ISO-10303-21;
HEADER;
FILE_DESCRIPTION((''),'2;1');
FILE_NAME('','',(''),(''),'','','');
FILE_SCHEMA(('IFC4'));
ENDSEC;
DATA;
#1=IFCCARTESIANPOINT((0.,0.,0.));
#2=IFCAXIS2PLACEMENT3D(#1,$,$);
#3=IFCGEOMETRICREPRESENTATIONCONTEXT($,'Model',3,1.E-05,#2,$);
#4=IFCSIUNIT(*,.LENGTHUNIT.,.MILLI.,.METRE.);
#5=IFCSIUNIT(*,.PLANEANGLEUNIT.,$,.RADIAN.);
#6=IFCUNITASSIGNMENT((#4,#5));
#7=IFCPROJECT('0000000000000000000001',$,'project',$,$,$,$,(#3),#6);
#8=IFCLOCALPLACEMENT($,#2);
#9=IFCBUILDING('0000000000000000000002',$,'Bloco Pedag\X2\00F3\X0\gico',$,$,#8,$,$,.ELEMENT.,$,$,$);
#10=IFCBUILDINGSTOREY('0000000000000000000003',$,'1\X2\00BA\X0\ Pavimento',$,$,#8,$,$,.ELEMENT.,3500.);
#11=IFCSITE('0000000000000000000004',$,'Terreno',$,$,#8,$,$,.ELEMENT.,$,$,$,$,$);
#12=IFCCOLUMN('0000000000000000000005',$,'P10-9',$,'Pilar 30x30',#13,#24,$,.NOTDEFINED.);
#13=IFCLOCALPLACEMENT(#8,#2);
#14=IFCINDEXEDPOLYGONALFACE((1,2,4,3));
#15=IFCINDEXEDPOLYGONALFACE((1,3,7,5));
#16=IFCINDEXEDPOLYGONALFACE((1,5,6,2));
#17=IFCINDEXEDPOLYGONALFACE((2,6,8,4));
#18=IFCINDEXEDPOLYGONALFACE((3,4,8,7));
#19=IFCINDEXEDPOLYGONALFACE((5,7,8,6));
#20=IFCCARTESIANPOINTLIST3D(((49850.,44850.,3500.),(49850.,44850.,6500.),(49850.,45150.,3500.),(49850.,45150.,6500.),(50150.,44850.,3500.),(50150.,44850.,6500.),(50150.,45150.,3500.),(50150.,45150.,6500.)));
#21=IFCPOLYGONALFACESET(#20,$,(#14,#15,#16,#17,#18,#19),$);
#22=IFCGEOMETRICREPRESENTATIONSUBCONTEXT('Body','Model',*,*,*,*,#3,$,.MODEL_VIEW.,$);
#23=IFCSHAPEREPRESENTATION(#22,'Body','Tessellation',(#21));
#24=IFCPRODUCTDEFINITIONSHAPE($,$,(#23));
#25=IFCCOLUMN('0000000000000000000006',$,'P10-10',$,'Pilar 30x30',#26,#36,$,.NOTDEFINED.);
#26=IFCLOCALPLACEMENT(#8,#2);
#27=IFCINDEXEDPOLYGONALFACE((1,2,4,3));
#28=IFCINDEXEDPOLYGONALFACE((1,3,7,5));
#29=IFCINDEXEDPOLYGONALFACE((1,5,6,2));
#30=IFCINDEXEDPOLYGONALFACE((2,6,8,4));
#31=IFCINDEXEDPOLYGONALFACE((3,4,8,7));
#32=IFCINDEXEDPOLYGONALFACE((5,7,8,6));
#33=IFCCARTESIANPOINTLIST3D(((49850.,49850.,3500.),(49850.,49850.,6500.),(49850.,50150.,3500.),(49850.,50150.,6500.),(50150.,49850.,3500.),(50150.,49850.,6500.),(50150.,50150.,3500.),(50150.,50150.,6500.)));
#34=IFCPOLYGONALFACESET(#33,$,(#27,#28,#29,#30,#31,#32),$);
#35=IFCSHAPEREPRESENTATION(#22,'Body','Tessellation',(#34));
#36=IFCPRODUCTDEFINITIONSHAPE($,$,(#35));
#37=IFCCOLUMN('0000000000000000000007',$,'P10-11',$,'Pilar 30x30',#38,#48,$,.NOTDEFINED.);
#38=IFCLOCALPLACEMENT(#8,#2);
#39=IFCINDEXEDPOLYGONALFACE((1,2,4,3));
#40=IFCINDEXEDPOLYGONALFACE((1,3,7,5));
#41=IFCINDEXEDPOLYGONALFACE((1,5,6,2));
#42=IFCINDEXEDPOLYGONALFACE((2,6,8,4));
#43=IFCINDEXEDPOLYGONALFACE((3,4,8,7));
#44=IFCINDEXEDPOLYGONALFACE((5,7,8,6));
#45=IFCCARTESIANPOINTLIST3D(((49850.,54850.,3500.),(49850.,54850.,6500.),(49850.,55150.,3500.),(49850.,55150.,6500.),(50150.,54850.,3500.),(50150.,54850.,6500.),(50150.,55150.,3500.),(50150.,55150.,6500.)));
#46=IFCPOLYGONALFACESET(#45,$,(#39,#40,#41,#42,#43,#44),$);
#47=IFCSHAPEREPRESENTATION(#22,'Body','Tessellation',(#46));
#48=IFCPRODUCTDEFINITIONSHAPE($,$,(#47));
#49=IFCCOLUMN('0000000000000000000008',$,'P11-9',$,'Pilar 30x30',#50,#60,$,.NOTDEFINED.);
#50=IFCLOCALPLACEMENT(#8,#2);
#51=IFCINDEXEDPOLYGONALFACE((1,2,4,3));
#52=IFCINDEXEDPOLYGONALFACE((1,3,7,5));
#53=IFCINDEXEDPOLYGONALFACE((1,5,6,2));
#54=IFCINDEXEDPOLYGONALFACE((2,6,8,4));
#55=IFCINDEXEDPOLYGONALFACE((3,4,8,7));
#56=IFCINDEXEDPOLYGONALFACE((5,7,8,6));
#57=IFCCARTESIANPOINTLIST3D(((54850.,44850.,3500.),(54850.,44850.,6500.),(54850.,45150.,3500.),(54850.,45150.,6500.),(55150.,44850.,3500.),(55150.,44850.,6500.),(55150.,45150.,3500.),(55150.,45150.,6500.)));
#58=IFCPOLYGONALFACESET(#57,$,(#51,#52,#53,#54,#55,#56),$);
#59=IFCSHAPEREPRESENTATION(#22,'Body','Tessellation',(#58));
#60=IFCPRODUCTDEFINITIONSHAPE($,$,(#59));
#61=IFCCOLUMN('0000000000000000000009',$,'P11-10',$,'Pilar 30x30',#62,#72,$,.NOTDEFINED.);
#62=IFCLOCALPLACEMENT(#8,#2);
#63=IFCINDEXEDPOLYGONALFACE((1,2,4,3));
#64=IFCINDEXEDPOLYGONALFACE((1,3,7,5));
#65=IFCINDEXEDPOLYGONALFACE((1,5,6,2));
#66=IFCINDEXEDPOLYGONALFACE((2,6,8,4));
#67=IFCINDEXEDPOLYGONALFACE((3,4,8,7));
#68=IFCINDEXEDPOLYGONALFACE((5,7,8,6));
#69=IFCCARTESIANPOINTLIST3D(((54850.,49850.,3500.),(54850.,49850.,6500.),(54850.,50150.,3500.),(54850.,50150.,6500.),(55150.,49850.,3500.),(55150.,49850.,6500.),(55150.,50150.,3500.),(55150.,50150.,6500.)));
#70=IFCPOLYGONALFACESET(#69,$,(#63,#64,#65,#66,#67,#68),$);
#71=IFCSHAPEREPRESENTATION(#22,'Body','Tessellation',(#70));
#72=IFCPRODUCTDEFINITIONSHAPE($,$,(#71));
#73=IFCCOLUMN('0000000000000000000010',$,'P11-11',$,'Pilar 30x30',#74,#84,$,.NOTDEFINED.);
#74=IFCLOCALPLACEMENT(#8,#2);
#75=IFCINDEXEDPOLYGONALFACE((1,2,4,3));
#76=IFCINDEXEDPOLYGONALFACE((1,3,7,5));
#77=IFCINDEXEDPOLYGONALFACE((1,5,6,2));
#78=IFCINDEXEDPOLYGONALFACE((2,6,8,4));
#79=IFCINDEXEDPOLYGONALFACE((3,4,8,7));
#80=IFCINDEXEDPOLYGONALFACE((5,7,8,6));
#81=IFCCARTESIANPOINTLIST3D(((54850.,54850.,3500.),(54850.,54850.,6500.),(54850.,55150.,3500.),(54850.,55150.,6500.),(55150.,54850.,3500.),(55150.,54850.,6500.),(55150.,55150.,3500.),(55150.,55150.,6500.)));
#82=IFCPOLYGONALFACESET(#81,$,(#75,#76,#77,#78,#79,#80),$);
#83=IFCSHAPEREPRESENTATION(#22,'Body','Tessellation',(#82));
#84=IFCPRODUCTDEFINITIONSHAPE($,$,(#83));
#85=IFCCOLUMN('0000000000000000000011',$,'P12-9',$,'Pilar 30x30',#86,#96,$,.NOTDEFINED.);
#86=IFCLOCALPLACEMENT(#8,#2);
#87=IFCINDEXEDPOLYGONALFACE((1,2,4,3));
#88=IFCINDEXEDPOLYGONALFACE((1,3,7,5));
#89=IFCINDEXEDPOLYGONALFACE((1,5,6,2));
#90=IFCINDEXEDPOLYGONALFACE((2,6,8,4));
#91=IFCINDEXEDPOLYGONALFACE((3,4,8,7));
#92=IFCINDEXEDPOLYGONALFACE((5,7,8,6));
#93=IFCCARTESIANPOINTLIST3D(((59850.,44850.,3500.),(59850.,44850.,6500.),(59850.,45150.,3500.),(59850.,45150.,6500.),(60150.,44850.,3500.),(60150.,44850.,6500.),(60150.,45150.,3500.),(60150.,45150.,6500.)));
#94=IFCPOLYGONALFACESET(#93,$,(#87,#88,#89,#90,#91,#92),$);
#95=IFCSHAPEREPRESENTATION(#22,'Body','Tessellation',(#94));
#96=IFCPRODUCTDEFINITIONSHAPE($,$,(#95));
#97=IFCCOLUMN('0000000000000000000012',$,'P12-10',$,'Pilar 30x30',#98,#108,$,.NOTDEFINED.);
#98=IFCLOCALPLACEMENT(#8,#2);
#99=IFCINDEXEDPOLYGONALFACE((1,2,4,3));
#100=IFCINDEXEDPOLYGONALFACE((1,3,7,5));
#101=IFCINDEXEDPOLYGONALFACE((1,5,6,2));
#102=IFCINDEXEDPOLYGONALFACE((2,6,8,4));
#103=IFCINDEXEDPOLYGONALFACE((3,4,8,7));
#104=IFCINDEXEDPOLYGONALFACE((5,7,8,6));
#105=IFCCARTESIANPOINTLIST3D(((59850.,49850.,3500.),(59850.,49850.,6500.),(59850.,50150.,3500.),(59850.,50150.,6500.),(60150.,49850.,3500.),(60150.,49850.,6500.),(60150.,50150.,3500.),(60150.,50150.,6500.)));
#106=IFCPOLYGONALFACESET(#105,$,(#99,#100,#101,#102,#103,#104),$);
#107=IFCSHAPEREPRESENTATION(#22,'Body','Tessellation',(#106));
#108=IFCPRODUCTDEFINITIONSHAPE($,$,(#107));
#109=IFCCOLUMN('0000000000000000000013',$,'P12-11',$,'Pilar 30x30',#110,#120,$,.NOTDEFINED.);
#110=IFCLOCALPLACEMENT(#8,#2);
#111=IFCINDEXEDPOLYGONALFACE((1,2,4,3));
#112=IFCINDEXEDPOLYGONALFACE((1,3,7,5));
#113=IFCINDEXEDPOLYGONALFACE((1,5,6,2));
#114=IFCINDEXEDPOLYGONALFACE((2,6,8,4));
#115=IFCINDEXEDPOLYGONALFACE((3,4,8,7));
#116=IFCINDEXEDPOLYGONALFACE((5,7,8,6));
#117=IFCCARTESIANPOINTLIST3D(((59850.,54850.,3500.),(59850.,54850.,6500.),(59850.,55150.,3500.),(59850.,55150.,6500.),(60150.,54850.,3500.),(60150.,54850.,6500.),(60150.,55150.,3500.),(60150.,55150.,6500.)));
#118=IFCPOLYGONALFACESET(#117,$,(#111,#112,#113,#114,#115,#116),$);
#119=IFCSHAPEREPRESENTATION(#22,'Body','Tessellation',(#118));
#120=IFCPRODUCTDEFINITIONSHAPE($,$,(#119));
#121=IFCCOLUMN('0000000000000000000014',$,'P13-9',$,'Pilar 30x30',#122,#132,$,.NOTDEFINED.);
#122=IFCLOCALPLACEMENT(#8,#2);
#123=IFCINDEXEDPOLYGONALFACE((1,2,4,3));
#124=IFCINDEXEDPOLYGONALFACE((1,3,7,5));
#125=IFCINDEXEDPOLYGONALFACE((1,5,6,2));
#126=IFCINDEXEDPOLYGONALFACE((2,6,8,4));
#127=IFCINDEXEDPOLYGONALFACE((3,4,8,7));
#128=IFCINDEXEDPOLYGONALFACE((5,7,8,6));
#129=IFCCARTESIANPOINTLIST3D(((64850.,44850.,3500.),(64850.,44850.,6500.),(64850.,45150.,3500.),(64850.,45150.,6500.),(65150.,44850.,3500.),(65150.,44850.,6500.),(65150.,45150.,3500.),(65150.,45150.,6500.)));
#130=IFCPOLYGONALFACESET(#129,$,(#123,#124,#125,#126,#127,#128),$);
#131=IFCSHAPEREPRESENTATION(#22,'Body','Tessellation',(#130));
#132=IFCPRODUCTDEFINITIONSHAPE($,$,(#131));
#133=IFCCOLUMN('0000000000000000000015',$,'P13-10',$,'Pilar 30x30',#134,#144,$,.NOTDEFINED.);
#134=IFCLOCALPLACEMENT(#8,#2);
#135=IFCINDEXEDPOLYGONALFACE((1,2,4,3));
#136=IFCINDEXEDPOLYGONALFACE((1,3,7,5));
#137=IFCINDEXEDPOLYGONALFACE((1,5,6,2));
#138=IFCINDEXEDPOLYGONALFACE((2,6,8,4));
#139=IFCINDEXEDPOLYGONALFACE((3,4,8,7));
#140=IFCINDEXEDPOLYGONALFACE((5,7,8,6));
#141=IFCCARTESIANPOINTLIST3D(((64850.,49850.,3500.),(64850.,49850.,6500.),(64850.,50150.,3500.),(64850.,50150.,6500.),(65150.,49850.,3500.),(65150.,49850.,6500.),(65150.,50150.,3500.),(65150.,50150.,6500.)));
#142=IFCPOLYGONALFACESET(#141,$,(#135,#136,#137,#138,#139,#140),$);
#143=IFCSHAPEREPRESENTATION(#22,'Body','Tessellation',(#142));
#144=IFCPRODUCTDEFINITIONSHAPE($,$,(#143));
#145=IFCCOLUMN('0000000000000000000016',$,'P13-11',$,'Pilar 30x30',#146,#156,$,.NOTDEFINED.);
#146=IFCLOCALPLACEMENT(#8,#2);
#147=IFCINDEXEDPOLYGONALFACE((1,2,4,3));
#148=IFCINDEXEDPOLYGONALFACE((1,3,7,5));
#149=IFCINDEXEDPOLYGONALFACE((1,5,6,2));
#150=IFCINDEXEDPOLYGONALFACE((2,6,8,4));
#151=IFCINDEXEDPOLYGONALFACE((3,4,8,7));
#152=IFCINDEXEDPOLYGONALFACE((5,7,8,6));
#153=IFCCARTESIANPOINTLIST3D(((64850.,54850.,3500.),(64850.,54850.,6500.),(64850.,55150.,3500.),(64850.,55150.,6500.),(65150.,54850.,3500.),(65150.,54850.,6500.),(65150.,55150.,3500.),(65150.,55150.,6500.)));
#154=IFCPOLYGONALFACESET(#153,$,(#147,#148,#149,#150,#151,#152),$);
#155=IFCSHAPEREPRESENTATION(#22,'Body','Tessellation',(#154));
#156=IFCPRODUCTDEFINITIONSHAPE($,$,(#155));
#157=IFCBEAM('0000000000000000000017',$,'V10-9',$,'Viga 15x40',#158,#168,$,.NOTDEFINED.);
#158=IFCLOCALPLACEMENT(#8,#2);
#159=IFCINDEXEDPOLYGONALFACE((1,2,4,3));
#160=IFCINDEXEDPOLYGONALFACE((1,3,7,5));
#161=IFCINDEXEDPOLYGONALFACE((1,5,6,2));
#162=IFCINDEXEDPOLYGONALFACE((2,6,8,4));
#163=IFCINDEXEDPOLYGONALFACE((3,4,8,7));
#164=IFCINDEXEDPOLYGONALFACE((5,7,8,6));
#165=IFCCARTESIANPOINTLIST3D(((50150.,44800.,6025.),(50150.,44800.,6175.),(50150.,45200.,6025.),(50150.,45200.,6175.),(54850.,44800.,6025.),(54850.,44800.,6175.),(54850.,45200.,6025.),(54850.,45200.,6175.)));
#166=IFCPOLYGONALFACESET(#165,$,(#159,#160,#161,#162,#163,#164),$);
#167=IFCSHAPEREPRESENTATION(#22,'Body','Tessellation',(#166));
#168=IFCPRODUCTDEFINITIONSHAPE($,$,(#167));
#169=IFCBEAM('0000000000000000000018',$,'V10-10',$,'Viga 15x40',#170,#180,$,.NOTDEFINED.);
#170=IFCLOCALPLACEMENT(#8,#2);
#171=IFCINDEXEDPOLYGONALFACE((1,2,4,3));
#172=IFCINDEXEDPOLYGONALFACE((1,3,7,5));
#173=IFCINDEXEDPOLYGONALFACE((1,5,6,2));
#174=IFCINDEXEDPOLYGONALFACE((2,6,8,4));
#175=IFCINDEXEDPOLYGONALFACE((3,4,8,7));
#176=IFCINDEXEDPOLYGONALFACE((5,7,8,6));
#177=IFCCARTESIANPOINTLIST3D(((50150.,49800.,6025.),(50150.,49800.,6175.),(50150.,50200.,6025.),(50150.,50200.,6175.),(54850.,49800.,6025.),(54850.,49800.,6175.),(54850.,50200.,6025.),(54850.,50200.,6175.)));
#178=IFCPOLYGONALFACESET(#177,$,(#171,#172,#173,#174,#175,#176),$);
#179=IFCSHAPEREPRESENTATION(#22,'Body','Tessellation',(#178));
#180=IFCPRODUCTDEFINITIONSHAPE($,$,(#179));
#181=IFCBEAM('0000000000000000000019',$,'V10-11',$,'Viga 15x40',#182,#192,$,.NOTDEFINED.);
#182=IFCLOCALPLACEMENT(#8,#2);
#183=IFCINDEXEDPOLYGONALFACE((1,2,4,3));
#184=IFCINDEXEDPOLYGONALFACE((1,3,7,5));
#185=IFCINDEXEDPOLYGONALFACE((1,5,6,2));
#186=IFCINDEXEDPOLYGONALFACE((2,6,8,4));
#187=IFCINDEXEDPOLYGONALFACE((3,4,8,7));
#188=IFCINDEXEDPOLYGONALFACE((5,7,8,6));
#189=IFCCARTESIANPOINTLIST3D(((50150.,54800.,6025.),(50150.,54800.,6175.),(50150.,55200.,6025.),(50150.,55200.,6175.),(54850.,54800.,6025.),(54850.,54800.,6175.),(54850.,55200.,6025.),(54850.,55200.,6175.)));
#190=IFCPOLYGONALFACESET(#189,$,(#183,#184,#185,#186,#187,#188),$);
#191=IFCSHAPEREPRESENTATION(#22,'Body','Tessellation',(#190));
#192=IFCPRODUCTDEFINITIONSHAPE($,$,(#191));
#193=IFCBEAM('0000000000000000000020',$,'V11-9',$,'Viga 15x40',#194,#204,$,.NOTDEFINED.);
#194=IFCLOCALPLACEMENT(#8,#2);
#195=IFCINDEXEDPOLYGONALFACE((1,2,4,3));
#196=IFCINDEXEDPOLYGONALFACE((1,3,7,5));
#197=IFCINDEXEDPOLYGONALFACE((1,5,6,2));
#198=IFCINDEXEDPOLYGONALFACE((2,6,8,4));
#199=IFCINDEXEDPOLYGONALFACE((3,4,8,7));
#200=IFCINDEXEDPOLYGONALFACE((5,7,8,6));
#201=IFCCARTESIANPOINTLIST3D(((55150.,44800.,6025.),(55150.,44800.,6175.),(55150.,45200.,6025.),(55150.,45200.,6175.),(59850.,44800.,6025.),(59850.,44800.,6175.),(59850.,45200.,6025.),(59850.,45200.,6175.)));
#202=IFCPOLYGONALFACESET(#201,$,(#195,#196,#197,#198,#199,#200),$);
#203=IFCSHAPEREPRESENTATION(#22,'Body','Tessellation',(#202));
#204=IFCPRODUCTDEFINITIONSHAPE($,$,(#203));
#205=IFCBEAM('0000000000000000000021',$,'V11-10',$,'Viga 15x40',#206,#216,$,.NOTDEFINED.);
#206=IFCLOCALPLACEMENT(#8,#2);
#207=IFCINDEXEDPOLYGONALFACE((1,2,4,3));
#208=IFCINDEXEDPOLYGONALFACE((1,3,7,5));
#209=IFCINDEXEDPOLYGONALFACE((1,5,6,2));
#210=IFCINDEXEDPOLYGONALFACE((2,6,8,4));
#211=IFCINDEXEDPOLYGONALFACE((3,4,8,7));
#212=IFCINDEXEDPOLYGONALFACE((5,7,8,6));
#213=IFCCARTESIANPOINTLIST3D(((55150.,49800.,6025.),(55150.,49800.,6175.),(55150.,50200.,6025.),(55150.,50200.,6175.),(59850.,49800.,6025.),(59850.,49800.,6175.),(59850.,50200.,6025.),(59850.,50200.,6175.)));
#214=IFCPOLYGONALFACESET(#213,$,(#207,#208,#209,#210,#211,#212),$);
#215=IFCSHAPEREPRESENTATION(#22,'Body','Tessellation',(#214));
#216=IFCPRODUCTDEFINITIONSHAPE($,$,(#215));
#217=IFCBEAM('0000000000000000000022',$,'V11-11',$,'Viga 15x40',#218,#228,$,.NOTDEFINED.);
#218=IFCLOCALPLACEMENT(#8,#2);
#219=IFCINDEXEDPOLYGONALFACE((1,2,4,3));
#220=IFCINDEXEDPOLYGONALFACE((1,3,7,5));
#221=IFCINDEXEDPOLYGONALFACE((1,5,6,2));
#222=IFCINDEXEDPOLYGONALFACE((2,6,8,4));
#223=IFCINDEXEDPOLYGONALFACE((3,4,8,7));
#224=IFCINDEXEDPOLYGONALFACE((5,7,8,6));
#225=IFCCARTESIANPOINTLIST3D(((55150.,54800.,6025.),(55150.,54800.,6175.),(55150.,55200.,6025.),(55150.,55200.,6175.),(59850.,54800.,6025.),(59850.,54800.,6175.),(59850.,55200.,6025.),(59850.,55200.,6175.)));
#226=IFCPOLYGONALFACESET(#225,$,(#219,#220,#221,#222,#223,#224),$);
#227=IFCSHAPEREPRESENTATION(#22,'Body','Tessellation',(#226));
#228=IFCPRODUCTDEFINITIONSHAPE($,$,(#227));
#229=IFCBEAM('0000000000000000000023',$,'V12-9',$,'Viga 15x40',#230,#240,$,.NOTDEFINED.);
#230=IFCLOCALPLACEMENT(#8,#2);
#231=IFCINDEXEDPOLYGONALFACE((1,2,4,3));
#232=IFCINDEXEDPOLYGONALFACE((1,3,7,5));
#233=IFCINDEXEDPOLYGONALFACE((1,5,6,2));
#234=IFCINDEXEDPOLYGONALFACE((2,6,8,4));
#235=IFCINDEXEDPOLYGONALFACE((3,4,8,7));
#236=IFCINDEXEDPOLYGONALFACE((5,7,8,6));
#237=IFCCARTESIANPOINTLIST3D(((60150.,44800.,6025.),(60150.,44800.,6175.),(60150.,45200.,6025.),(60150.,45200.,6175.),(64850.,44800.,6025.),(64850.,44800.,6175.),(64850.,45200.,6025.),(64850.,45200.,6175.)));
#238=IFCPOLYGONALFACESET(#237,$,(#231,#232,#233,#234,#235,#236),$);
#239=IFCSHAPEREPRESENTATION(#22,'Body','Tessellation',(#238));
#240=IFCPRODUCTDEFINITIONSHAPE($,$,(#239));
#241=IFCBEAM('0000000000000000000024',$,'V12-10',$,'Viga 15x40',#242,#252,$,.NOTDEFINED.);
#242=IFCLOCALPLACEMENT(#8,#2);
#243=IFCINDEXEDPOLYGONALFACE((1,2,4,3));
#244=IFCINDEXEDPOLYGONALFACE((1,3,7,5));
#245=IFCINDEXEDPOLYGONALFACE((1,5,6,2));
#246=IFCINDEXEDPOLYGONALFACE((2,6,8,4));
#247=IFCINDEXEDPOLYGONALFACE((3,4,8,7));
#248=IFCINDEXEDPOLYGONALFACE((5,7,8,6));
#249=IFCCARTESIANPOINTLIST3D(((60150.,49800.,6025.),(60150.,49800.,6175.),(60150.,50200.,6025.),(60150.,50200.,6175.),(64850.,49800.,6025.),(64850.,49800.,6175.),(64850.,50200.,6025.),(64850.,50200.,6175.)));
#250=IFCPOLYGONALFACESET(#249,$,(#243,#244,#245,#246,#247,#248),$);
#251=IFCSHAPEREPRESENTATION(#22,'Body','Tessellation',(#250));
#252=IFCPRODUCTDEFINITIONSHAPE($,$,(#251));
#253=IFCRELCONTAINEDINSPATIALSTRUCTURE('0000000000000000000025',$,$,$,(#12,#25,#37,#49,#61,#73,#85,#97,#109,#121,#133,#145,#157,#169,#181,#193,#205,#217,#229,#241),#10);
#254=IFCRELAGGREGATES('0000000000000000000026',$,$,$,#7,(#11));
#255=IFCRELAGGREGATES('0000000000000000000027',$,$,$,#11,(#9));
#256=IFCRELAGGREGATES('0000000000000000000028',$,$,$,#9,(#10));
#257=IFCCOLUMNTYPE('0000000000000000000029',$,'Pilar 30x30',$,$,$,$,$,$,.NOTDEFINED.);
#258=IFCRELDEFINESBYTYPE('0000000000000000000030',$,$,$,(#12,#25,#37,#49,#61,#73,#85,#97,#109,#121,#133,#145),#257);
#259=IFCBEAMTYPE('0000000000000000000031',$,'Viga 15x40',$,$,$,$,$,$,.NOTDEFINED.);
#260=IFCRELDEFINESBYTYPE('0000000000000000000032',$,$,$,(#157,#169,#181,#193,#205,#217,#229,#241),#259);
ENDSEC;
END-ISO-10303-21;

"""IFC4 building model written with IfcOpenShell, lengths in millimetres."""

from ifc_helpers import new_model, si_unit, frame, origin, origin_2d, place, context, subcontext, project, spatial, rectangle, extrude, type_object, element, save


model = new_model("IFC4")

# Units and contexts
model_context = context("Model", 3, precision=1e-05, world=origin())
body_context = subcontext(model_context, "Body", "Model", "MODEL_VIEW")
ifc_project = project(units=[si_unit("LENGTHUNIT", "METRE", prefix="MILLI"), si_unit("PLANEANGLEUNIT", "RADIAN")], contexts=[model_context])

# Site, building, storey
placement = place(None, origin())
site = spatial("IfcSite", under=ifc_project, at=placement, Name="Terreno", CompositionType="ELEMENT")
building = spatial("IfcBuilding", under=site, at=placement, Name="Bloco Pedagógico", CompositionType="ELEMENT")
storey = spatial("IfcBuildingStorey", under=building, at=placement, Name="1º Pavimento", CompositionType="ELEMENT", Elevation=3500.0)

# Columns
column_type = type_object("IfcColumnType", Name="Pilar 30x30", PredefinedType="NOTDEFINED")
for number, where, z_axis, x_axis, name in (
    (1, (50000.0, 45000.0, 3500.0), (0.0, 0.0, 1.0), (1.0, 0.0, 0.0), "P10-9"),
    (2, (50000.0, 50000.0, 3500.0), (0.0, 0.0, 1.0), (1.0, 0.0, 0.0), "P10-10"),
    (3, (50000.0, 55000.0, 3500.0), (0.0, 0.0, 1.0), (1.0, 0.0, 0.0), "P10-11"),
    (4, (55000.0, 45000.0, 3500.0), (0.0, 0.0, 1.0), (1.0, 0.0, 0.0), "P11-9"),
    (5, (55000.0, 50000.0, 3500.0), (0.0, 0.0, 1.0), (1.0, 0.0, 0.0), "P11-10"),
    (6, (55000.0, 55000.0, 3500.0), (0.0, 0.0, 1.0), (1.0, 0.0, 0.0), "P11-11"),
    (7, (60000.0, 45000.0, 3500.0), (0.0, 0.0, 1.0), (1.0, 0.0, 0.0), "P12-9"),
    (8, (60000.0, 50000.0, 3500.0), (0.0, 0.0, 1.0), (1.0, 0.0, 0.0), "P12-10"),
    (9, (60000.0, 55000.0, 3500.0), (0.0, 0.0, 1.0), (1.0, 0.0, 0.0), "P12-11"),
    (10, (65000.0, 45000.0, 3500.0), (0.0, 0.0, 1.0), (1.0, 0.0, 0.0), "P13-9"),
    (11, (65000.0, 50000.0, 3500.0), (0.0, 0.0, 1.0), (1.0, 0.0, 0.0), "P13-10"),
    (12, (65000.0, 55000.0, 3500.0), (0.0, 0.0, 1.0), (1.0, 0.0, 0.0), "P13-11"),
):
    element("IfcColumn", number, at=place(None, frame(where, z_axis=z_axis, x_axis=x_axis)), inside=storey, type_object=column_type, Name=name, ObjectType="Pilar 30x30", PredefinedType="NOTDEFINED", context=body_context, shape_type="SweptSolid", body=[
        extrude(rectangle(XDim=300.0, YDim=300.0, at=origin_2d()), None, (0.0, 0.0, 1.0), 3000.0),
    ])

# Beams
beam_type = type_object("IfcBeamType", Name="Viga 15x40", PredefinedType="NOTDEFINED")
for number, where, z_axis, x_axis, name in (
    (13, (50150.0, 45000.0, 6100.0), (1.0, 0.0, 0.0), (0.0, 1.0, 0.0), "V10-9"),
    (14, (50150.0, 50000.0, 6100.0), (1.0, 0.0, 0.0), (0.0, 1.0, 0.0), "V10-10"),
    (15, (50150.0, 55000.0, 6100.0), (1.0, 0.0, 0.0), (0.0, 1.0, 0.0), "V10-11"),
    (16, (55150.0, 45000.0, 6100.0), (1.0, 0.0, 0.0), (0.0, 1.0, 0.0), "V11-9"),
    (17, (55150.0, 50000.0, 6100.0), (1.0, 0.0, 0.0), (0.0, 1.0, 0.0), "V11-10"),
    (18, (55150.0, 55000.0, 6100.0), (1.0, 0.0, 0.0), (0.0, 1.0, 0.0), "V11-11"),
    (19, (60150.0, 45000.0, 6100.0), (1.0, 0.0, 0.0), (0.0, 1.0, 0.0), "V12-9"),
    (20, (60150.0, 50000.0, 6100.0), (1.0, 0.0, 0.0), (0.0, 1.0, 0.0), "V12-10"),
):
    element("IfcBeam", number, at=place(None, frame(where, z_axis=z_axis, x_axis=x_axis)), inside=storey, type_object=beam_type, Name=name, ObjectType="Viga 15x40", PredefinedType="NOTDEFINED", context=body_context, shape_type="SweptSolid", body=[
        extrude(rectangle(XDim=400.0, YDim=150.0, at=origin_2d()), None, (0.0, 0.0, 1.0), 4700.0),
    ])

save(model, "model.ifc")
